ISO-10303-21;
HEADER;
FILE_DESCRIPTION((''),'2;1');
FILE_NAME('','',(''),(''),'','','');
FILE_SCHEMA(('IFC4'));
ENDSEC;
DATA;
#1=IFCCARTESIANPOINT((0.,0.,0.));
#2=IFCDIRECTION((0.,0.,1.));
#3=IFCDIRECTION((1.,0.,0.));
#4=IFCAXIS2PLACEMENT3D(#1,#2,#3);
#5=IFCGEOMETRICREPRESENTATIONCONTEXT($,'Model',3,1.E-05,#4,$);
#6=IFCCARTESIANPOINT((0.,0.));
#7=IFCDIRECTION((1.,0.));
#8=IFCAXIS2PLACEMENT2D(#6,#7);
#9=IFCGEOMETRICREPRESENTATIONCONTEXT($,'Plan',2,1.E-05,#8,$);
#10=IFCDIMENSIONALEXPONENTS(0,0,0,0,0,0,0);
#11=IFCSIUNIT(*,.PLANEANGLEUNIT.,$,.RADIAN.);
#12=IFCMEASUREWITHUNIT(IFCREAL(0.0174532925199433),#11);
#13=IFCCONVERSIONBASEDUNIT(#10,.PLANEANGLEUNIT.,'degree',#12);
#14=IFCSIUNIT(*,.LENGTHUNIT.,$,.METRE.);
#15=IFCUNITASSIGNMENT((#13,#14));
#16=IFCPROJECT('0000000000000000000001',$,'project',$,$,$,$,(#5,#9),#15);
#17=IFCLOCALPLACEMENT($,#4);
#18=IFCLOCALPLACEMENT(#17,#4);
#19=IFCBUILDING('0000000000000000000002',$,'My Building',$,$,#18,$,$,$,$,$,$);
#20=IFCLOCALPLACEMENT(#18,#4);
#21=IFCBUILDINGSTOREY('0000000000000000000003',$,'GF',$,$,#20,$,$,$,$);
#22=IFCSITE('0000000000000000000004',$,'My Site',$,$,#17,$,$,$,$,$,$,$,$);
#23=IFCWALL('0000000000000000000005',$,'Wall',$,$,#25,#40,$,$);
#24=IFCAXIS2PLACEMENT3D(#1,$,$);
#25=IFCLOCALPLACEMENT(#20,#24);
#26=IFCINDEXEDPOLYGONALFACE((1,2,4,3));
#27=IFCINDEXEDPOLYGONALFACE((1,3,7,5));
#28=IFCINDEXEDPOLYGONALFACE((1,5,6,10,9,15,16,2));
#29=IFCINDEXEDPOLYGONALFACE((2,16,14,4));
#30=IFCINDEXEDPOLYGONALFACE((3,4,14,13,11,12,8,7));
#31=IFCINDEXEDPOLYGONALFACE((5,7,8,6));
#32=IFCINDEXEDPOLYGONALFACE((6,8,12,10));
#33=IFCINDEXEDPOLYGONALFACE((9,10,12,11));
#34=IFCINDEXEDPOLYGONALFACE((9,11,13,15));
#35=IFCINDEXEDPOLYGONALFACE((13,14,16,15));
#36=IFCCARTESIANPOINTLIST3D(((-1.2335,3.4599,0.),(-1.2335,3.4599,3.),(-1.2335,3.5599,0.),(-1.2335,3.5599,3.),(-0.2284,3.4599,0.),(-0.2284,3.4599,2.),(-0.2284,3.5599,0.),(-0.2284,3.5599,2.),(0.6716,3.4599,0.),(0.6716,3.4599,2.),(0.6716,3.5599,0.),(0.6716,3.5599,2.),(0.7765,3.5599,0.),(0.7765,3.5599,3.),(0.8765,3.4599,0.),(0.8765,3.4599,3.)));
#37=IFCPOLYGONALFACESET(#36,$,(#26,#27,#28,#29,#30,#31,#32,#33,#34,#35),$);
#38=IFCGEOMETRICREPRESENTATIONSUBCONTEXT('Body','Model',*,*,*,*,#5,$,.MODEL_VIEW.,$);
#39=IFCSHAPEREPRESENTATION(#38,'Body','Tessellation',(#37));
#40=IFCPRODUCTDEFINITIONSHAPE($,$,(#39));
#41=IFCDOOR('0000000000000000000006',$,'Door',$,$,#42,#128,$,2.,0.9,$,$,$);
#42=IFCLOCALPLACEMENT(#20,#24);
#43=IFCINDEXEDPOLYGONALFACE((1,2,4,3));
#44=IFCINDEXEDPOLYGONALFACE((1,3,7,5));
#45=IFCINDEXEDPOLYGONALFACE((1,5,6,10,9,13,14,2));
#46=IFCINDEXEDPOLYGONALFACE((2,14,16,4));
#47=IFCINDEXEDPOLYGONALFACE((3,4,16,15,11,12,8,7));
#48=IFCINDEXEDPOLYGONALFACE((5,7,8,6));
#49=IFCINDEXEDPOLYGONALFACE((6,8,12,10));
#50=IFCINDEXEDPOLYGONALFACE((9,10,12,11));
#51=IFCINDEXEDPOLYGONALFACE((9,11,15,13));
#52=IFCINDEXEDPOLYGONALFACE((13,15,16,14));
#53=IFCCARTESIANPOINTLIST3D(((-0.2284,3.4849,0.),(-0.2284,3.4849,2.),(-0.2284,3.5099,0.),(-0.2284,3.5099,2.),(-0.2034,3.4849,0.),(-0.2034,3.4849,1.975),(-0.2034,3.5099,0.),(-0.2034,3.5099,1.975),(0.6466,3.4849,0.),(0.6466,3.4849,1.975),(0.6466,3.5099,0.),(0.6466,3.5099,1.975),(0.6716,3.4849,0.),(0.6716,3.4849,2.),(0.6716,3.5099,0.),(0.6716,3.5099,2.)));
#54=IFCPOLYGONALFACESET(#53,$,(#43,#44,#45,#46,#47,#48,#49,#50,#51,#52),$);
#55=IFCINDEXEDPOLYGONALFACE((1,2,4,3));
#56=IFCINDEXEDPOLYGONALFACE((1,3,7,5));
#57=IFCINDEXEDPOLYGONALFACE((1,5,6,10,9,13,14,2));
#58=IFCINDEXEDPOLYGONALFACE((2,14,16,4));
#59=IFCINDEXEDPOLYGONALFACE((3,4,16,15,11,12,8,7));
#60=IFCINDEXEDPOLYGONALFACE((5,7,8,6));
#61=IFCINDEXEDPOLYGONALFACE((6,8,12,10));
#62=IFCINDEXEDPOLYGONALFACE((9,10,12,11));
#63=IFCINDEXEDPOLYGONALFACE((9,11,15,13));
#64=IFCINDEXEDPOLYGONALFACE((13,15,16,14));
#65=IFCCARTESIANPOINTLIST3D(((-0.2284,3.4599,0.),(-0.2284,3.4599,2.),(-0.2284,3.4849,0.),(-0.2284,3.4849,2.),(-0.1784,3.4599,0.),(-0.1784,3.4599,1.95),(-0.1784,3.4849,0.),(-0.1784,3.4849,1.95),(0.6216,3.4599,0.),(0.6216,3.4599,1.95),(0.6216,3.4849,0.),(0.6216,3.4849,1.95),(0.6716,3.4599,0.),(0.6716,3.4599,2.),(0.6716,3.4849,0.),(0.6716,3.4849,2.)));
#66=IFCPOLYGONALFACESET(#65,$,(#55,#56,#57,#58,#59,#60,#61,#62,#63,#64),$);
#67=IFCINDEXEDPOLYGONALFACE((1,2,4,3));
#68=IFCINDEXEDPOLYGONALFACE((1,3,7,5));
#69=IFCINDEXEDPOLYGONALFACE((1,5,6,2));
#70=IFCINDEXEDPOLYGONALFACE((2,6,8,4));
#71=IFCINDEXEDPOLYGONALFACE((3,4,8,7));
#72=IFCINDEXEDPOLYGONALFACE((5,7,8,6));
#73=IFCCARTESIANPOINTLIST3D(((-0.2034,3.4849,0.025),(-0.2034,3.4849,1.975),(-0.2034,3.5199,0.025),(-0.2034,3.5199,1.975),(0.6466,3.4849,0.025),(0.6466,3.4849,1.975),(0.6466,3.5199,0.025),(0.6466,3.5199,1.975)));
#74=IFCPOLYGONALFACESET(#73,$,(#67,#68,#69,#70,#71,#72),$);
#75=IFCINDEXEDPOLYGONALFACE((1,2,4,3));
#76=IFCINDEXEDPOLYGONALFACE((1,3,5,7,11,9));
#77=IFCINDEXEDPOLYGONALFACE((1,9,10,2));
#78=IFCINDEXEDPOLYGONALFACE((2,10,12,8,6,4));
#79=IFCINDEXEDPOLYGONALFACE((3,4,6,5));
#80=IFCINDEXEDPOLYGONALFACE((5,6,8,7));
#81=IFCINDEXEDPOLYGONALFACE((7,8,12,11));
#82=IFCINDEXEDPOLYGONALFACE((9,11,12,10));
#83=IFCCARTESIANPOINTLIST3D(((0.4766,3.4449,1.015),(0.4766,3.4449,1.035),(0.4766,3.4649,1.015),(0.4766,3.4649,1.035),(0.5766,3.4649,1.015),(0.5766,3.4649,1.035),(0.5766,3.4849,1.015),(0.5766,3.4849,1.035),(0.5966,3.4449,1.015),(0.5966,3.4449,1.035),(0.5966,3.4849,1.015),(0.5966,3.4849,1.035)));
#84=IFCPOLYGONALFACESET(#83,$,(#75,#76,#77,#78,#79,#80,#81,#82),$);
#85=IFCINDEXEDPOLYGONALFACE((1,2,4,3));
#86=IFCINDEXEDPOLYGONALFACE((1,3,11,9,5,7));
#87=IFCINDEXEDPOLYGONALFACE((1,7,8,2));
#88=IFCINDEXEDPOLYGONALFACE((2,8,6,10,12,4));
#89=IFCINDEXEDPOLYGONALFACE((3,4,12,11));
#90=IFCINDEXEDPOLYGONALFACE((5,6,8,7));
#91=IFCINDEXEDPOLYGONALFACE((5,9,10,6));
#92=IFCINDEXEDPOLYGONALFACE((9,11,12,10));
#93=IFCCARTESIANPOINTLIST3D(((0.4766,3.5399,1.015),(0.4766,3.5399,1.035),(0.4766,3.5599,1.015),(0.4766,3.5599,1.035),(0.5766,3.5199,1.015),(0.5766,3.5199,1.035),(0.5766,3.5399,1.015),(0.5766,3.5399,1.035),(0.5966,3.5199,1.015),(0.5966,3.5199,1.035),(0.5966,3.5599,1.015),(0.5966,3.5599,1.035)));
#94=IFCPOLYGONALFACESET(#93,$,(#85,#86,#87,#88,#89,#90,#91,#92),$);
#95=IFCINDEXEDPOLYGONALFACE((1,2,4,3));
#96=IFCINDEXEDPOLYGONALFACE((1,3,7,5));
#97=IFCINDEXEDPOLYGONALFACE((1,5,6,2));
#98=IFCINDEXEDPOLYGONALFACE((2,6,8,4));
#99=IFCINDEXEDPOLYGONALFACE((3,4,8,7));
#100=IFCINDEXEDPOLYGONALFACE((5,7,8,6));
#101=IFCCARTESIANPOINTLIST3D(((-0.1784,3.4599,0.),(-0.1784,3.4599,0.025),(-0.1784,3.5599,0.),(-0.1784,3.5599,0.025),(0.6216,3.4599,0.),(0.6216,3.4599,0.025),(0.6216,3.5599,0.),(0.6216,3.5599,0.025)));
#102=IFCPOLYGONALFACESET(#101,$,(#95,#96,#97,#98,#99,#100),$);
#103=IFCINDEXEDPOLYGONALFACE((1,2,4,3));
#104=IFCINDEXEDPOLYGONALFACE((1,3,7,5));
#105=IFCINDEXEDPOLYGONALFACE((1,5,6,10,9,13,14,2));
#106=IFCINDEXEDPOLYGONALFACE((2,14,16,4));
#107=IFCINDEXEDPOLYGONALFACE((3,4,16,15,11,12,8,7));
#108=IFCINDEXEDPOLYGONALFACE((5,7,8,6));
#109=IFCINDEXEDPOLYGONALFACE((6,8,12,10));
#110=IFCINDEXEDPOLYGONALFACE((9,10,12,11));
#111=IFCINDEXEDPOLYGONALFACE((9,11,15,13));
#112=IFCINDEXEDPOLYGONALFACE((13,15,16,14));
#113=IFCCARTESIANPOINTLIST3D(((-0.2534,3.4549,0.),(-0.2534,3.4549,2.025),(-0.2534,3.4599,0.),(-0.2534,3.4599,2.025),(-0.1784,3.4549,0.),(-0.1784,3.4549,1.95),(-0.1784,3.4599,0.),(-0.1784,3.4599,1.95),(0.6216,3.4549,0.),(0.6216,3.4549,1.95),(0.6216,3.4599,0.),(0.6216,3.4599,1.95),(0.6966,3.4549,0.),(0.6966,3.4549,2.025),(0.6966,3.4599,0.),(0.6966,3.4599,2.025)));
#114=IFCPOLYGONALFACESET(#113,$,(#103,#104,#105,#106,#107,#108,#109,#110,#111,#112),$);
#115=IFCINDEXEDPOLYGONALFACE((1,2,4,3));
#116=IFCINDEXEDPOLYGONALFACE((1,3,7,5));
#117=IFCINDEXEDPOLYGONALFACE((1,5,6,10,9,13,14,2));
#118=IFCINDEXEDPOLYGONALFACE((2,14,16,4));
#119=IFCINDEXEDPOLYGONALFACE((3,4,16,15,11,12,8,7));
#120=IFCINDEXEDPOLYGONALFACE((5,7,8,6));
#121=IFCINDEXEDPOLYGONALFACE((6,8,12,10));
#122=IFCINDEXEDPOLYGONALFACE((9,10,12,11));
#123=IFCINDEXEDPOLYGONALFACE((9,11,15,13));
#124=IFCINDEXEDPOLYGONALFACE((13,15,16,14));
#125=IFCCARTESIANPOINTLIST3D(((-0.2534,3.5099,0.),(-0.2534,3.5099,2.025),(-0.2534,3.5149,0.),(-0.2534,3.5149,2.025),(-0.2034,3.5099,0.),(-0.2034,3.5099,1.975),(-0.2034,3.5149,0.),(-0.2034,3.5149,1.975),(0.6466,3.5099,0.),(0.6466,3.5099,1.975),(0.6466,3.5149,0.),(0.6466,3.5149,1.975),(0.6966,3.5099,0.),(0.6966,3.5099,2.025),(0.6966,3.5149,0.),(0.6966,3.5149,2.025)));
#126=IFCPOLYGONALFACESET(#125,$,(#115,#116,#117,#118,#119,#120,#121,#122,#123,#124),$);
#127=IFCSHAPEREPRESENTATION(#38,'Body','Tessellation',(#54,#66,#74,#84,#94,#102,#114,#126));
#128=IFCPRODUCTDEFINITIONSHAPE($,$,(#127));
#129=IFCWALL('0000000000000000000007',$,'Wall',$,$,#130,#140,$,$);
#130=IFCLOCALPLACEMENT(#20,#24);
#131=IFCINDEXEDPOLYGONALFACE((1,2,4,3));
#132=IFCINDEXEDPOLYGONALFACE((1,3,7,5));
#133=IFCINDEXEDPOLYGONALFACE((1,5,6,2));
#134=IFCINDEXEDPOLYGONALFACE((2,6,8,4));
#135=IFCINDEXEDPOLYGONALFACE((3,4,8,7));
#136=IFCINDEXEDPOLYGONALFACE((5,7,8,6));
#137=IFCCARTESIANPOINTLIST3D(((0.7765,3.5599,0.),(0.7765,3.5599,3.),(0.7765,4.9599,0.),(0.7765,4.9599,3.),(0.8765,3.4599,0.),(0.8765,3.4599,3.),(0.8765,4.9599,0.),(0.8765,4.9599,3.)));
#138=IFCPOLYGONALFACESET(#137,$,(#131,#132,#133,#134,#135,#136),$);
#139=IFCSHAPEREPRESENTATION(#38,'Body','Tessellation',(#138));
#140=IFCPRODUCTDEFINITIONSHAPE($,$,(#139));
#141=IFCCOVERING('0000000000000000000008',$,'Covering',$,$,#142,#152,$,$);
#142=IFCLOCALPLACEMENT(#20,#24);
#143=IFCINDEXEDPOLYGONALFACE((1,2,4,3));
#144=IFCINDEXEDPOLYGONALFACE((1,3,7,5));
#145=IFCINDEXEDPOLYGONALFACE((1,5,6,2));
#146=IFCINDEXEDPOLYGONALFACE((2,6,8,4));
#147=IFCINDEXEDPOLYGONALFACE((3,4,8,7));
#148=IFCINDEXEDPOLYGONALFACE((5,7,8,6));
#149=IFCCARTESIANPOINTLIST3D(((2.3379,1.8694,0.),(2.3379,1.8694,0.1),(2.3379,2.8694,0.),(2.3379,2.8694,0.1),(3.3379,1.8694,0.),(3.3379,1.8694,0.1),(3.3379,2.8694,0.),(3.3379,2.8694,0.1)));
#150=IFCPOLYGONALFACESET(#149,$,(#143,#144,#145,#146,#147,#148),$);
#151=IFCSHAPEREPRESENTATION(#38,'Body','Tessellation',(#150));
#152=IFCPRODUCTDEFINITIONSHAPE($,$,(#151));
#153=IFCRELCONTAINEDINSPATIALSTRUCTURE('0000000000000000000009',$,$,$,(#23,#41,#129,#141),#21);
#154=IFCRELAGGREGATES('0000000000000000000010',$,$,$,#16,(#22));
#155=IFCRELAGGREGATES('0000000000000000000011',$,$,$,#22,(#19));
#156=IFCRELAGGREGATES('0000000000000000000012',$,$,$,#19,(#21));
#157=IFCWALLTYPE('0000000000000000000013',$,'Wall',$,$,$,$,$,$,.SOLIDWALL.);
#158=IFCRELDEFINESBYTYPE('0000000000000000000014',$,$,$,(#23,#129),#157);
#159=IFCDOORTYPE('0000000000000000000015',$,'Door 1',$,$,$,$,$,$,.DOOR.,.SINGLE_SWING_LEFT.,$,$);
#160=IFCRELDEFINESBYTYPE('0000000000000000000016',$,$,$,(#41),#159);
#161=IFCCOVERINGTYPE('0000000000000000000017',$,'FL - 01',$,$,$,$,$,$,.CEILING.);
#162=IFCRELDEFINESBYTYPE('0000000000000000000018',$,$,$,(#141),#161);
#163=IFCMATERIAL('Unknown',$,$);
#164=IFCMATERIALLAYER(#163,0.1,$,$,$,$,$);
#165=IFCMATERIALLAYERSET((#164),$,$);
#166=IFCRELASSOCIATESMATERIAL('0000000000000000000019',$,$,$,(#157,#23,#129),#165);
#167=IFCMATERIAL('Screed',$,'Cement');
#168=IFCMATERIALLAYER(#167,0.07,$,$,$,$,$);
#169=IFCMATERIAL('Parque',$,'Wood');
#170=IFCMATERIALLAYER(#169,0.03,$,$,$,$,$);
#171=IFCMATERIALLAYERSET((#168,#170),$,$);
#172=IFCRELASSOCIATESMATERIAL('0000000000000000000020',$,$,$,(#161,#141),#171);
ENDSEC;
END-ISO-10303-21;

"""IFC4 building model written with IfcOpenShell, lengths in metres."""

from ifc_helpers import new_model, entity, si_unit, converted_unit, frame, origin_with_axes, origin_2d_with_axis, place, context, subcontext, project, spatial, line, indexed_curve, outline, extrude, shape, source, transform, mapped, material, layer, layer_set, layer_usage, type_object, type_shapes, element, fill, save


model = new_model("IFC4")

# Units and contexts
model_context = context("Model", 3, precision=1e-05, world=origin_with_axes())
plan_context = context("Plan", 2, precision=1e-05, world=origin_2d_with_axis())
body_context_1 = subcontext(model_context, "Body", "Model", "MODEL_VIEW")
body_context_2 = subcontext(plan_context, "Body", "Plan", "PLAN_VIEW")
ifc_project = project(units=[converted_unit("PLANEANGLEUNIT", "degree", entity("IfcReal", 0.0174532925199433), si_unit("PLANEANGLEUNIT", "RADIAN"), dimensions=[0, 0, 0, 0, 0, 0, 0]), si_unit("LENGTHUNIT", "METRE")], contexts=[model_context, plan_context])

# Site, building, storey
site_placement = place(None, origin_with_axes())
site = spatial("IfcSite", under=ifc_project, at=site_placement, Name="My Site")
building_placement = place(site_placement, origin_with_axes())
building = spatial("IfcBuilding", under=site, at=building_placement, Name="My Building")
storey_placement = place(building_placement, origin_with_axes())
storey = spatial("IfcBuildingStorey", under=building, at=storey_placement, Name="GF")

# Shared definitions
ifc_material_1 = material(Name="Unknown")

# Shared definitions
ifc_layer_1 = layer(ifc_material_1, 0.1)
ifc_layer_set_1 = layer_set([ifc_layer_1])
wall_type = type_object("IfcWallType", Name="Wall", PredefinedType="SOLIDWALL", material=ifc_layer_set_1)
shared_shape_1 = source(origin_with_axes(), body_context_1, "Body", "SweptSolid", [
    extrude(outline(indexed_curve([(0.0, 0.0), (0.9, 0.0), (0.9, 2.0), (0.0, 2.0)], segments=[line(1, 2, 3, 4, 1)])), frame((0.0, -0.6, 0.0), z_axis=(0.0, -1.0, 0.0), x_axis=(1.0, 0.0, 0.0)), (0.0, 0.0, -1.0), 1.2),
])
door_type = type_object("IfcDoorType", Name="Door 1", OperationType="SINGLE_SWING_LEFT", PredefinedType="DOOR")
shared_shape_2 = source(origin_with_axes(), body_context_1, "Body", "SweptSolid", [
    extrude(outline(indexed_curve([(0.0, 0.0), (0.0, 2.0), (0.9, 2.0), (0.9, 0.0), (0.875, 0.0), (0.875, 1.975), (0.025, 1.975), (0.025, 0.0)], segments=[line(1, 2, 3, 4, 5, 6, 7, 8, 1)])), frame((0.0, 0.025, 0.0), z_axis=(0.0, -1.0, 0.0), x_axis=(1.0, 0.0, 0.0)), (0.0, 0.0, -1.0), 0.025),
    extrude(outline(indexed_curve([(0.0, 0.0), (0.0, 2.0), (0.9, 2.0), (0.9, 0.0), (0.85, 0.0), (0.85, 1.95), (0.05, 1.95), (0.05, 0.0)], segments=[line(1, 2, 3, 4, 5, 6, 7, 8, 1)])), frame((0.0, 0.0, 0.0), z_axis=(0.0, -1.0, 0.0), x_axis=(1.0, 0.0, 0.0)), (0.0, 0.0, -1.0), 0.025),
    extrude(outline(indexed_curve([(0.0, 0.0), (0.85, 0.0), (0.85, 0.035), (0.0, 0.035)], segments=[line(1, 2, 3, 4, 1)])), frame((0.025, 0.025, 0.025), z_axis=(0.0, 0.0, 1.0), x_axis=(1.0, 0.0, 0.0)), (0.0, 0.0, 1.0), 1.95),
    extrude(outline(indexed_curve([(0.0, 0.0), (0.0, -0.04), (-0.12, -0.04), (-0.12, -0.02), (-0.02, -0.02), (-0.02, 0.0)], segments=[line(1, 2, 3, 4, 5, 6, 1)])), frame((0.825, 0.025, 1.015), z_axis=(0.0, 0.0, 1.0), x_axis=(1.0, 0.0, 0.0)), (0.0, 0.0, 1.0), 0.02),
    extrude(outline(indexed_curve([(0.0, 0.0), (0.0, 0.04), (-0.12, 0.04), (-0.12, 0.02), (-0.02, 0.02), (-0.02, 0.0)], segments=[line(1, 2, 3, 4, 5, 6, 1)])), frame((0.825, 0.06, 1.015), z_axis=(0.0, 0.0, 1.0), x_axis=(1.0, 0.0, 0.0)), (0.0, 0.0, 1.0), 0.02),
    extrude(outline(indexed_curve([(0.0, 0.0), (0.8, 0.0), (0.8, 0.1), (0.0, 0.1)], segments=[line(1, 2, 3, 4, 1)])), frame((0.05, 0.0, 0.0), z_axis=(0.0, 0.0, 1.0), x_axis=(1.0, 0.0, 0.0)), (0.0, 0.0, 1.0), 0.025),
    extrude(outline(indexed_curve([(0.0, 0.0), (0.0, 2.025), (0.95, 2.025), (0.95, 0.0), (0.875, 0.0), (0.875, 1.95), (0.075, 1.95), (0.075, 0.0)], segments=[line(1, 2, 3, 4, 5, 6, 7, 8, 1)])), frame((-0.025, -0.005, 0.0), z_axis=(0.0, -1.0, 0.0), x_axis=(1.0, 0.0, 0.0)), (0.0, 0.0, -1.0), 0.005),
    extrude(outline(indexed_curve([(0.0, 0.0), (0.0, 2.025), (0.95, 2.025), (0.95, 0.0), (0.9, 0.0), (0.9, 1.975), (0.05, 1.975), (0.05, 0.0)], segments=[line(1, 2, 3, 4, 5, 6, 7, 8, 1)])), frame((-0.025, 0.05, 0.0), z_axis=(0.0, -1.0, 0.0), x_axis=(1.0, 0.0, 0.0)), (0.0, 0.0, -1.0), 0.005),
])
shared_shape_3 = source(origin_with_axes(), body_context_2, "Body", "Curve2D", [
    entity("IfcIndexedPolyCurve", entity("IfcCartesianPointList2D", [[0.0, 0.0], [0.0, 0.05], [0.025, 0.05], [0.025, 0.025], [0.05, 0.025], [0.05, 0.0]]), [entity("IfcLineIndex", [1, 2, 3, 4, 5, 6, 1])]),
    entity("IfcIndexedPolyCurve", entity("IfcCartesianPointList2D", [[0.9, 0.0], [0.9, 0.05], [0.875, 0.05], [0.875, 0.025], [0.85, 0.025], [0.85, 0.0]]), [entity("IfcLineIndex", [1, 2, 3, 4, 5, 6, 1])]),
    entity("IfcTrimmedCurve", entity("IfcEllipse", entity("IfcAxis2Placement2D", entity("IfcCartesianPoint", [0.06, 0.05]), entity("IfcDirection", [1.0, 0.0])), 0.815, 0.85), [entity("IfcCartesianPoint", [0.875, 0.05])], [entity("IfcCartesianPoint", [0.06, 0.9])], True, "CARTESIAN"),
    entity("IfcIndexedPolyCurve", entity("IfcCartesianPointList2D", [[0.025, 0.05], [0.06, 0.05], [0.06, 0.9], [0.025, 0.9]]), [entity("IfcLineIndex", [1, 2, 3, 4, 1])]),
])
type_shapes(door_type, [shared_shape_2, shared_shape_3])

# Wall, opening, door
ifc_layer_usage_1 = layer_usage(ifc_layer_set_1, "AXIS2", "POSITIVE", 0.0)
wall_1_placement = place(storey_placement, frame((-1.2335, 3.4599, 0.0), z_axis=(0.0, 0.0, 1.0), x_axis=(1.0, 0.0, 0.0)))
wall_1 = element("IfcWall", 1, at=wall_1_placement, inside=storey, type_object=wall_type, material=ifc_layer_usage_1, Name="Wall", context=body_context_1, shape_type="SweptSolid", body=[
    extrude(outline(indexed_curve([(0.0, 0.0), (0.0, 0.1), (2.01, 0.1), (2.11, 0.0)], segments=[line(1, 2, 3, 4, 1)])), origin_with_axes(), (0.0, 0.0, 1.0), 3.0),
])
opening_1_placement = place(wall_1_placement, frame((1.0051, 0.0, 0.0), z_axis=(0.0, 0.0, 1.0), x_axis=(1.0, 0.0, 0.0)))
opening_1 = element("IfcOpeningElement", 2, at=opening_1_placement, cuts=wall_1, PredefinedType="OPENING", context=body_context_1, shape_type="MappedRepresentation", body=[
    mapped(shared_shape_1, transform((0.0, 0.0, 0.0), x_axis=(1.0, 0.0, 0.0), y_axis=(0.0, 1.0, 0.0), z_axis=(0.0, 0.0, 1.0), scale=1.0)),
])
door_1_placement = place(opening_1_placement, origin_with_axes())
door_1 = element("IfcDoor", 3, at=door_1_placement, inside=storey, type_object=door_type, Name="Door", OverallHeight=2.0, OverallWidth=0.9, shapes=[
    shape(body_context_1, "Body", "MappedRepresentation", [mapped(shared_shape_2, transform((0.0, 0.0, 0.0), x_axis=(1.0, 0.0, 0.0), y_axis=(0.0, 1.0, 0.0), z_axis=(0.0, 0.0, 1.0), scale=1.0))]),
    shape(body_context_2, "Body", "MappedRepresentation", [mapped(shared_shape_3, transform((0.0, 0.0, 0.0), x_axis=(1.0, 0.0, 0.0), y_axis=(0.0, 1.0, 0.0), z_axis=(0.0, 0.0, 1.0), scale=1.0))]),
])
fill(opening_1, door_1)

# Wall
ifc_layer_usage_2 = layer_usage(ifc_layer_set_1, "AXIS2", "POSITIVE", 0.0)
wall_2_placement = place(storey_placement, frame((0.8765, 3.4599, 0.0), z_axis=(0.0, 0.0, 1.0), x_axis=(0.0, 1.0, 0.0)))
element("IfcWall", 4, at=wall_2_placement, inside=storey, type_object=wall_type, material=ifc_layer_usage_2, Name="Wall", context=body_context_1, shape_type="SweptSolid", body=[
    extrude(outline(indexed_curve([(0.0, 0.0), (0.1, 0.1), (1.5, 0.1), (1.5, 0.0)], segments=[line(1, 2, 3, 4, 1)])), origin_with_axes(), (0.0, 0.0, 1.0), 3.0),
])

# Covering
ifc_material_2 = material(Name="Screed", Category="Cement")
ifc_layer_2 = layer(ifc_material_2, 0.07)
ifc_material_3 = material(Name="Parque", Category="Wood")
ifc_layer_3 = layer(ifc_material_3, 0.03)
ifc_layer_set_2 = layer_set([ifc_layer_2, ifc_layer_3])
ifc_layer_usage_3 = layer_usage(ifc_layer_set_2, "AXIS3", "POSITIVE", 0.0)
covering_type = type_object("IfcCoveringType", Name="FL - 01", PredefinedType="CEILING", material=ifc_layer_set_2)
covering_placement = place(storey_placement, frame((2.3379, 1.8694, 0.0), z_axis=(0.0, 0.0, 1.0), x_axis=(1.0, 0.0, 0.0)))
element("IfcCovering", 5, at=covering_placement, inside=storey, type_object=covering_type, material=ifc_layer_usage_3, Name="Covering", context=body_context_1, shape_type="SweptSolid", body=[
    extrude(outline(indexed_curve([(0.0, 0.0), (1.0, 0.0), (1.0, 1.0), (0.0, 1.0), (0.0, 0.0)])), None, (0.0, 0.0, 1.0), 0.1),
])

save(model, "model.ifc")
